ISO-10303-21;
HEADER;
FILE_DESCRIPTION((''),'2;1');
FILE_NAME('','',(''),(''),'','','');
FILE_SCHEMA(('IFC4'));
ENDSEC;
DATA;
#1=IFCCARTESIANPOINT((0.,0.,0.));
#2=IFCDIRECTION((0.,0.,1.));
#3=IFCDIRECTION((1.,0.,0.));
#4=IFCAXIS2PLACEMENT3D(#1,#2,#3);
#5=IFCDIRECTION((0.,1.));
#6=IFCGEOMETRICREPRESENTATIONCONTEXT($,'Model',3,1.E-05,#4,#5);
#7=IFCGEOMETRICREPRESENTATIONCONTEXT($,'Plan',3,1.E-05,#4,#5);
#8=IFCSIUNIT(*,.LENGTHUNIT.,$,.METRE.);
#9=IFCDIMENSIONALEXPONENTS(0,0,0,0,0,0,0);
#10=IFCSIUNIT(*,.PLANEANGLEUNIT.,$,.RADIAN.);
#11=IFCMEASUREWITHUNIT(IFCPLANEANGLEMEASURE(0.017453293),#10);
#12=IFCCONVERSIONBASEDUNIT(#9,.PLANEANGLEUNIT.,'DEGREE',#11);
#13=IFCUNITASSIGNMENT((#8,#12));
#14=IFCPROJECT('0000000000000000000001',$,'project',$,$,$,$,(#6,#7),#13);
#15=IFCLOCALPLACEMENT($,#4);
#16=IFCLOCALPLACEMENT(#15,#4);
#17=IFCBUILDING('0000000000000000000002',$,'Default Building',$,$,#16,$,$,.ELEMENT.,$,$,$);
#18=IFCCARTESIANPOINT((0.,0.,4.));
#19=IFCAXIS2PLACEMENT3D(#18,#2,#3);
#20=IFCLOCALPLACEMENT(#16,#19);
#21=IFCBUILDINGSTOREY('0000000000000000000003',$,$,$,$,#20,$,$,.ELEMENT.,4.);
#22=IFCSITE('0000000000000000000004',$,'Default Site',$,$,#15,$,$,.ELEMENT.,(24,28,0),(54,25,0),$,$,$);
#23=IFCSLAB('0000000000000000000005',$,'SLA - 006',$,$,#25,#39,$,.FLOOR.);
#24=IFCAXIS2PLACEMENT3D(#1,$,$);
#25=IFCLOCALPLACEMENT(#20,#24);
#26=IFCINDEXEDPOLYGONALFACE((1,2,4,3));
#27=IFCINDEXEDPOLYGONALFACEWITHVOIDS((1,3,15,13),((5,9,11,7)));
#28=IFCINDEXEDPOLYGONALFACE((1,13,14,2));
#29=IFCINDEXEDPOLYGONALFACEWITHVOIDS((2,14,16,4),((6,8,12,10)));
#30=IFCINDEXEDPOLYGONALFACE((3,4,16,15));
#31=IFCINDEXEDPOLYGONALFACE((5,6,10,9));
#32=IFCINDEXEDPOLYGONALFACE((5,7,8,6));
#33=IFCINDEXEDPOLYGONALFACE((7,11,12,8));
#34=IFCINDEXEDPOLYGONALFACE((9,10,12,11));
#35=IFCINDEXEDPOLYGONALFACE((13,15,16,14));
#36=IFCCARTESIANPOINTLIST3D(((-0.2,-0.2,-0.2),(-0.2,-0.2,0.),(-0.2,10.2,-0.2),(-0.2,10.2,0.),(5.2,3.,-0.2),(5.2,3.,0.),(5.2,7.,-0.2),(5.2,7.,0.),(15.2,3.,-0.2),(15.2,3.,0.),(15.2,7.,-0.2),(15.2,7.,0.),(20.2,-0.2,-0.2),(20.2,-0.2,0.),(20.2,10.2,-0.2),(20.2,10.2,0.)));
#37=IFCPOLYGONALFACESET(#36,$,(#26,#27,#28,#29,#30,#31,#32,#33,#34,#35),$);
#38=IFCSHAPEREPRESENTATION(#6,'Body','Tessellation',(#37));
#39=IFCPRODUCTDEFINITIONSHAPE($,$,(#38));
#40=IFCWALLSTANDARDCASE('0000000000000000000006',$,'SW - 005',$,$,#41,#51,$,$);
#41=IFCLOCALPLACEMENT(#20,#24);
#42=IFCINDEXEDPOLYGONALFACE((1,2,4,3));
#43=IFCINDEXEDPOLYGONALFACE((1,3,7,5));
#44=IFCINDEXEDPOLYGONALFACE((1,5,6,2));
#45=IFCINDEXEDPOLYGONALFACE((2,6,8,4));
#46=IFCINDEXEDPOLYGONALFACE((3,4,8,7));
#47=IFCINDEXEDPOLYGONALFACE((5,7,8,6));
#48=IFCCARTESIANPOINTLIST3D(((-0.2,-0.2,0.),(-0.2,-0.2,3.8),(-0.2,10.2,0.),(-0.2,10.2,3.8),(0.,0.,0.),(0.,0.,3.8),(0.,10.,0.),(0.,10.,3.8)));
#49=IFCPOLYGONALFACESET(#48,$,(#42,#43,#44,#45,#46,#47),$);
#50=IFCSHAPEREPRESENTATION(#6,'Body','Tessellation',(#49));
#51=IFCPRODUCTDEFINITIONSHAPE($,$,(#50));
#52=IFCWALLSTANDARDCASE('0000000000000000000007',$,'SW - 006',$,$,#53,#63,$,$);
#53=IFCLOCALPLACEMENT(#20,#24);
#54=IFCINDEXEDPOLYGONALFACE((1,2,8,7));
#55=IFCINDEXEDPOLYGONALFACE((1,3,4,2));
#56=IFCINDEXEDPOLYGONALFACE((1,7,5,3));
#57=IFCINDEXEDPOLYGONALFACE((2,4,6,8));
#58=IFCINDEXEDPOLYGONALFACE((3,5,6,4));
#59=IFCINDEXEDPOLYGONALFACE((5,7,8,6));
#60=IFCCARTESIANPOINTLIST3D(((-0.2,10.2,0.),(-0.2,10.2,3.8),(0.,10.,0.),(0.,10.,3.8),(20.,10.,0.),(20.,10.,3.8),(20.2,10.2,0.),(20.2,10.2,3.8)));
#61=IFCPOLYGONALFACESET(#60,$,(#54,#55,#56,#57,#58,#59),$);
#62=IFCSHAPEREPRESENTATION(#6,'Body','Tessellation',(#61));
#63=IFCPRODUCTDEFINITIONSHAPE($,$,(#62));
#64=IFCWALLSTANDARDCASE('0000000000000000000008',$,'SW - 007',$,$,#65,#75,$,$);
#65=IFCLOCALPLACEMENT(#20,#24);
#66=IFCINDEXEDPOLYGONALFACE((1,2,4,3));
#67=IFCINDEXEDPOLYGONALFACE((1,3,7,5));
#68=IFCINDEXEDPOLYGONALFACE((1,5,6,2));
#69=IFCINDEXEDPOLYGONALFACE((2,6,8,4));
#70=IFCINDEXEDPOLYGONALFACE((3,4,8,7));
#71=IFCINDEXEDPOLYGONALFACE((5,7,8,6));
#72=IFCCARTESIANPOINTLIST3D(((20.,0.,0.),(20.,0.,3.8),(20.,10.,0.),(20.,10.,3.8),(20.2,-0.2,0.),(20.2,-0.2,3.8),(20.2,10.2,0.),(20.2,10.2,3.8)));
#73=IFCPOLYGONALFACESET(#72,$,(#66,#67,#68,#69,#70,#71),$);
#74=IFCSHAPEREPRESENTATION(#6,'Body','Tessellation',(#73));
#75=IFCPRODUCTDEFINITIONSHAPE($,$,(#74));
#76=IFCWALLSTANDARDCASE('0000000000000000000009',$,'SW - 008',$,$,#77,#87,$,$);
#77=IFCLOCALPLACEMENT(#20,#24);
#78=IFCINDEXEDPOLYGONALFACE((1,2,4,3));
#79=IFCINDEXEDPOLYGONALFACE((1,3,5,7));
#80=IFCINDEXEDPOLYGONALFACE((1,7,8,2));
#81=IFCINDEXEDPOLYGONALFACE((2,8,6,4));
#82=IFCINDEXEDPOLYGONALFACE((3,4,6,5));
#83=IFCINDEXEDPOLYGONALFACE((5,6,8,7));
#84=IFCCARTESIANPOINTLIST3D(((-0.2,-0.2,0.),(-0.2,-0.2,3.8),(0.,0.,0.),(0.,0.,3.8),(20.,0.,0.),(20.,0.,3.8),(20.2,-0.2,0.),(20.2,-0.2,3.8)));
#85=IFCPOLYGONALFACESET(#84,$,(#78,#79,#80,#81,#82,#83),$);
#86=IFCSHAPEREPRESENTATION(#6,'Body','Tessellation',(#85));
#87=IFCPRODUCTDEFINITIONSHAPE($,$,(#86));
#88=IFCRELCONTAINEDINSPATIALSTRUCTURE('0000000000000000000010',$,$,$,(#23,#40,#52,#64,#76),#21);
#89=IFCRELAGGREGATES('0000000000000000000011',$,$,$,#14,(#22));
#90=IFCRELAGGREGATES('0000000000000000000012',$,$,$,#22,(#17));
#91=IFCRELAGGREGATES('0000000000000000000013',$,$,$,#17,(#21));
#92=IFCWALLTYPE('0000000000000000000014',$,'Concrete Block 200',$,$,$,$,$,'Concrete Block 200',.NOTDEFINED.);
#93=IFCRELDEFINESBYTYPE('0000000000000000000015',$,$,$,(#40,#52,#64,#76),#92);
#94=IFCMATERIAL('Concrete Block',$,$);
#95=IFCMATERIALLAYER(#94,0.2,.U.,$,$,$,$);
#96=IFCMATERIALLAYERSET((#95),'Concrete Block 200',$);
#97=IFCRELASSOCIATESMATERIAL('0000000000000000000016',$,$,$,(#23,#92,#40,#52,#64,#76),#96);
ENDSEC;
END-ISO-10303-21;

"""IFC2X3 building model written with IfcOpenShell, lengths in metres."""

from ifc_helpers import new_model, entity, si_unit, converted_unit, direction, frame, origin_with_axes, place, context, project, spatial, polyline, outline, extrude, material, layer, layer_set, layer_usage, type_object, element, save


model = new_model("IFC2X3")

# Units and contexts
model_context = context("Model", 3, precision=1e-05, world=origin_with_axes(), true_north=direction((0.0, 1.0)))
plan_context = context("Plan", 3, precision=1e-05, world=origin_with_axes(), true_north=direction((0.0, 1.0)))
ifc_project = project(units=[si_unit("LENGTHUNIT", "METRE"), converted_unit("PLANEANGLEUNIT", "DEGREE", entity("IfcPlaneAngleMeasure", 0.017453293), si_unit("PLANEANGLEUNIT", "RADIAN"), dimensions=[0, 0, 0, 0, 0, 0, 0])], contexts=[model_context, plan_context])

# Site, building, storey
site_placement = place(None, origin_with_axes())
site = spatial("IfcSite", under=ifc_project, at=site_placement, Name="Default Site", CompositionType="ELEMENT", RefLatitude=(24, 28, 0), RefLongitude=(54, 25, 0))
building_placement = place(site_placement, origin_with_axes())
building = spatial("IfcBuilding", under=site, at=building_placement, Name="Default Building", CompositionType="ELEMENT")
storey_placement = place(building_placement, frame((0.0, 0.0, 4.0), z_axis=(0.0, 0.0, 1.0), x_axis=(1.0, 0.0, 0.0)))
storey = spatial("IfcBuildingStorey", under=building, at=storey_placement, CompositionType="ELEMENT", Elevation=4.0)

# Slab, opening
ifc_material = material(Name="Concrete Block")
ifc_layer = layer(ifc_material, 0.2, ventilated="UNKNOWN")
ifc_layer_set = layer_set([ifc_layer], Name="Concrete Block 200")
ifc_layer_usage_1 = layer_usage(ifc_layer_set, "AXIS3", "NEGATIVE", 0.2)
slab_placement = place(storey_placement, frame((-0.2, -0.2, -0.2), z_axis=(0.0, 0.0, 1.0), x_axis=(1.0, 0.0, 0.0)))
slab = element("IfcSlab", 1, at=slab_placement, inside=storey, material=ifc_layer_usage_1, Name="SLA - 006", PredefinedType="FLOOR", context=model_context, shape_type="SweptSolid", body=[
    extrude(outline(polyline([(0.0, 0.0), (20.4, 0.0), (20.4, 10.4), (0.0, 10.4), (0.0, 0.0)])), origin_with_axes(), (0.0, 0.0, 1.0), 0.2),
])
opening_placement = place(slab_placement, origin_with_axes())
element("IfcOpeningElement", 2, at=opening_placement, cuts=slab, context=model_context, shape_type="SweptSolid", body=[
    extrude(outline(polyline([(15.4, 3.2), (5.4, 3.2), (5.4, 7.2), (15.4, 7.2), (15.4, 3.2)])), origin_with_axes(), (0.0, 0.0, 1.0), 0.2),
])

# Walls
ifc_layer_usage_2 = layer_usage(ifc_layer_set, "AXIS2", "POSITIVE", 0.0)
wall_type = type_object("IfcWallType", Name="Concrete Block 200", ElementType="Concrete Block 200", PredefinedType="NOTDEFINED", material=ifc_layer_set)
wall_1_placement = place(storey_placement, frame((0.0, 0.0, 0.0), z_axis=(0.0, 0.0, 1.0), x_axis=(0.0, 1.0, 0.0)))
element("IfcWallStandardCase", 3, at=wall_1_placement, inside=storey, type_object=wall_type, material=ifc_layer_usage_2, Name="SW - 005", context=model_context, shape_type="SweptSolid", body=[
    extrude(outline(polyline([(0.0, 0.0), (10.0, 0.0), (10.2, 0.2), (-0.2, 0.2), (0.0, 0.0)])), origin_with_axes(), (0.0, 0.0, 1.0), 3.8),
])
ifc_layer_usage_3 = layer_usage(ifc_layer_set, "AXIS2", "POSITIVE", 0.0)
wall_2_placement = place(storey_placement, frame((0.0, 10.0, 0.0), z_axis=(0.0, 0.0, 1.0), x_axis=(1.0, 0.0, 0.0)))
element("IfcWallStandardCase", 4, at=wall_2_placement, inside=storey, type_object=wall_type, material=ifc_layer_usage_3, Name="SW - 006", context=model_context, shape_type="SweptSolid", body=[
    extrude(outline(polyline([(0.0, 0.0), (20.0, 0.0), (20.2, 0.2), (-0.2, 0.2), (0.0, 0.0)])), origin_with_axes(), (0.0, 0.0, 1.0), 3.8),
])
ifc_layer_usage_4 = layer_usage(ifc_layer_set, "AXIS2", "POSITIVE", 0.0)
wall_3_placement = place(storey_placement, frame((20.0, 10.0, 0.0), z_axis=(0.0, 0.0, 1.0), x_axis=(0.0, -1.0, 0.0)))
element("IfcWallStandardCase", 5, at=wall_3_placement, inside=storey, type_object=wall_type, material=ifc_layer_usage_4, Name="SW - 007", context=model_context, shape_type="SweptSolid", body=[
    extrude(outline(polyline([(0.0, 0.0), (10.0, 0.0), (10.2, 0.2), (-0.2, 0.2), (0.0, 0.0)])), origin_with_axes(), (0.0, 0.0, 1.0), 3.8),
])
ifc_layer_usage_5 = layer_usage(ifc_layer_set, "AXIS2", "POSITIVE", 0.0)
wall_4_placement = place(storey_placement, frame((20.0, 0.0, 0.0), z_axis=(0.0, 0.0, 1.0), x_axis=(-1.0, 0.0, 0.0)))
element("IfcWallStandardCase", 6, at=wall_4_placement, inside=storey, type_object=wall_type, material=ifc_layer_usage_5, Name="SW - 008", context=model_context, shape_type="SweptSolid", body=[
    extrude(outline(polyline([(0.0, 0.0), (20.0, 0.0), (20.2, 0.2), (-0.2, 0.2), (0.0, 0.0)])), origin_with_axes(), (0.0, 0.0, 1.0), 3.8),
])

save(model, "model.ifc")
